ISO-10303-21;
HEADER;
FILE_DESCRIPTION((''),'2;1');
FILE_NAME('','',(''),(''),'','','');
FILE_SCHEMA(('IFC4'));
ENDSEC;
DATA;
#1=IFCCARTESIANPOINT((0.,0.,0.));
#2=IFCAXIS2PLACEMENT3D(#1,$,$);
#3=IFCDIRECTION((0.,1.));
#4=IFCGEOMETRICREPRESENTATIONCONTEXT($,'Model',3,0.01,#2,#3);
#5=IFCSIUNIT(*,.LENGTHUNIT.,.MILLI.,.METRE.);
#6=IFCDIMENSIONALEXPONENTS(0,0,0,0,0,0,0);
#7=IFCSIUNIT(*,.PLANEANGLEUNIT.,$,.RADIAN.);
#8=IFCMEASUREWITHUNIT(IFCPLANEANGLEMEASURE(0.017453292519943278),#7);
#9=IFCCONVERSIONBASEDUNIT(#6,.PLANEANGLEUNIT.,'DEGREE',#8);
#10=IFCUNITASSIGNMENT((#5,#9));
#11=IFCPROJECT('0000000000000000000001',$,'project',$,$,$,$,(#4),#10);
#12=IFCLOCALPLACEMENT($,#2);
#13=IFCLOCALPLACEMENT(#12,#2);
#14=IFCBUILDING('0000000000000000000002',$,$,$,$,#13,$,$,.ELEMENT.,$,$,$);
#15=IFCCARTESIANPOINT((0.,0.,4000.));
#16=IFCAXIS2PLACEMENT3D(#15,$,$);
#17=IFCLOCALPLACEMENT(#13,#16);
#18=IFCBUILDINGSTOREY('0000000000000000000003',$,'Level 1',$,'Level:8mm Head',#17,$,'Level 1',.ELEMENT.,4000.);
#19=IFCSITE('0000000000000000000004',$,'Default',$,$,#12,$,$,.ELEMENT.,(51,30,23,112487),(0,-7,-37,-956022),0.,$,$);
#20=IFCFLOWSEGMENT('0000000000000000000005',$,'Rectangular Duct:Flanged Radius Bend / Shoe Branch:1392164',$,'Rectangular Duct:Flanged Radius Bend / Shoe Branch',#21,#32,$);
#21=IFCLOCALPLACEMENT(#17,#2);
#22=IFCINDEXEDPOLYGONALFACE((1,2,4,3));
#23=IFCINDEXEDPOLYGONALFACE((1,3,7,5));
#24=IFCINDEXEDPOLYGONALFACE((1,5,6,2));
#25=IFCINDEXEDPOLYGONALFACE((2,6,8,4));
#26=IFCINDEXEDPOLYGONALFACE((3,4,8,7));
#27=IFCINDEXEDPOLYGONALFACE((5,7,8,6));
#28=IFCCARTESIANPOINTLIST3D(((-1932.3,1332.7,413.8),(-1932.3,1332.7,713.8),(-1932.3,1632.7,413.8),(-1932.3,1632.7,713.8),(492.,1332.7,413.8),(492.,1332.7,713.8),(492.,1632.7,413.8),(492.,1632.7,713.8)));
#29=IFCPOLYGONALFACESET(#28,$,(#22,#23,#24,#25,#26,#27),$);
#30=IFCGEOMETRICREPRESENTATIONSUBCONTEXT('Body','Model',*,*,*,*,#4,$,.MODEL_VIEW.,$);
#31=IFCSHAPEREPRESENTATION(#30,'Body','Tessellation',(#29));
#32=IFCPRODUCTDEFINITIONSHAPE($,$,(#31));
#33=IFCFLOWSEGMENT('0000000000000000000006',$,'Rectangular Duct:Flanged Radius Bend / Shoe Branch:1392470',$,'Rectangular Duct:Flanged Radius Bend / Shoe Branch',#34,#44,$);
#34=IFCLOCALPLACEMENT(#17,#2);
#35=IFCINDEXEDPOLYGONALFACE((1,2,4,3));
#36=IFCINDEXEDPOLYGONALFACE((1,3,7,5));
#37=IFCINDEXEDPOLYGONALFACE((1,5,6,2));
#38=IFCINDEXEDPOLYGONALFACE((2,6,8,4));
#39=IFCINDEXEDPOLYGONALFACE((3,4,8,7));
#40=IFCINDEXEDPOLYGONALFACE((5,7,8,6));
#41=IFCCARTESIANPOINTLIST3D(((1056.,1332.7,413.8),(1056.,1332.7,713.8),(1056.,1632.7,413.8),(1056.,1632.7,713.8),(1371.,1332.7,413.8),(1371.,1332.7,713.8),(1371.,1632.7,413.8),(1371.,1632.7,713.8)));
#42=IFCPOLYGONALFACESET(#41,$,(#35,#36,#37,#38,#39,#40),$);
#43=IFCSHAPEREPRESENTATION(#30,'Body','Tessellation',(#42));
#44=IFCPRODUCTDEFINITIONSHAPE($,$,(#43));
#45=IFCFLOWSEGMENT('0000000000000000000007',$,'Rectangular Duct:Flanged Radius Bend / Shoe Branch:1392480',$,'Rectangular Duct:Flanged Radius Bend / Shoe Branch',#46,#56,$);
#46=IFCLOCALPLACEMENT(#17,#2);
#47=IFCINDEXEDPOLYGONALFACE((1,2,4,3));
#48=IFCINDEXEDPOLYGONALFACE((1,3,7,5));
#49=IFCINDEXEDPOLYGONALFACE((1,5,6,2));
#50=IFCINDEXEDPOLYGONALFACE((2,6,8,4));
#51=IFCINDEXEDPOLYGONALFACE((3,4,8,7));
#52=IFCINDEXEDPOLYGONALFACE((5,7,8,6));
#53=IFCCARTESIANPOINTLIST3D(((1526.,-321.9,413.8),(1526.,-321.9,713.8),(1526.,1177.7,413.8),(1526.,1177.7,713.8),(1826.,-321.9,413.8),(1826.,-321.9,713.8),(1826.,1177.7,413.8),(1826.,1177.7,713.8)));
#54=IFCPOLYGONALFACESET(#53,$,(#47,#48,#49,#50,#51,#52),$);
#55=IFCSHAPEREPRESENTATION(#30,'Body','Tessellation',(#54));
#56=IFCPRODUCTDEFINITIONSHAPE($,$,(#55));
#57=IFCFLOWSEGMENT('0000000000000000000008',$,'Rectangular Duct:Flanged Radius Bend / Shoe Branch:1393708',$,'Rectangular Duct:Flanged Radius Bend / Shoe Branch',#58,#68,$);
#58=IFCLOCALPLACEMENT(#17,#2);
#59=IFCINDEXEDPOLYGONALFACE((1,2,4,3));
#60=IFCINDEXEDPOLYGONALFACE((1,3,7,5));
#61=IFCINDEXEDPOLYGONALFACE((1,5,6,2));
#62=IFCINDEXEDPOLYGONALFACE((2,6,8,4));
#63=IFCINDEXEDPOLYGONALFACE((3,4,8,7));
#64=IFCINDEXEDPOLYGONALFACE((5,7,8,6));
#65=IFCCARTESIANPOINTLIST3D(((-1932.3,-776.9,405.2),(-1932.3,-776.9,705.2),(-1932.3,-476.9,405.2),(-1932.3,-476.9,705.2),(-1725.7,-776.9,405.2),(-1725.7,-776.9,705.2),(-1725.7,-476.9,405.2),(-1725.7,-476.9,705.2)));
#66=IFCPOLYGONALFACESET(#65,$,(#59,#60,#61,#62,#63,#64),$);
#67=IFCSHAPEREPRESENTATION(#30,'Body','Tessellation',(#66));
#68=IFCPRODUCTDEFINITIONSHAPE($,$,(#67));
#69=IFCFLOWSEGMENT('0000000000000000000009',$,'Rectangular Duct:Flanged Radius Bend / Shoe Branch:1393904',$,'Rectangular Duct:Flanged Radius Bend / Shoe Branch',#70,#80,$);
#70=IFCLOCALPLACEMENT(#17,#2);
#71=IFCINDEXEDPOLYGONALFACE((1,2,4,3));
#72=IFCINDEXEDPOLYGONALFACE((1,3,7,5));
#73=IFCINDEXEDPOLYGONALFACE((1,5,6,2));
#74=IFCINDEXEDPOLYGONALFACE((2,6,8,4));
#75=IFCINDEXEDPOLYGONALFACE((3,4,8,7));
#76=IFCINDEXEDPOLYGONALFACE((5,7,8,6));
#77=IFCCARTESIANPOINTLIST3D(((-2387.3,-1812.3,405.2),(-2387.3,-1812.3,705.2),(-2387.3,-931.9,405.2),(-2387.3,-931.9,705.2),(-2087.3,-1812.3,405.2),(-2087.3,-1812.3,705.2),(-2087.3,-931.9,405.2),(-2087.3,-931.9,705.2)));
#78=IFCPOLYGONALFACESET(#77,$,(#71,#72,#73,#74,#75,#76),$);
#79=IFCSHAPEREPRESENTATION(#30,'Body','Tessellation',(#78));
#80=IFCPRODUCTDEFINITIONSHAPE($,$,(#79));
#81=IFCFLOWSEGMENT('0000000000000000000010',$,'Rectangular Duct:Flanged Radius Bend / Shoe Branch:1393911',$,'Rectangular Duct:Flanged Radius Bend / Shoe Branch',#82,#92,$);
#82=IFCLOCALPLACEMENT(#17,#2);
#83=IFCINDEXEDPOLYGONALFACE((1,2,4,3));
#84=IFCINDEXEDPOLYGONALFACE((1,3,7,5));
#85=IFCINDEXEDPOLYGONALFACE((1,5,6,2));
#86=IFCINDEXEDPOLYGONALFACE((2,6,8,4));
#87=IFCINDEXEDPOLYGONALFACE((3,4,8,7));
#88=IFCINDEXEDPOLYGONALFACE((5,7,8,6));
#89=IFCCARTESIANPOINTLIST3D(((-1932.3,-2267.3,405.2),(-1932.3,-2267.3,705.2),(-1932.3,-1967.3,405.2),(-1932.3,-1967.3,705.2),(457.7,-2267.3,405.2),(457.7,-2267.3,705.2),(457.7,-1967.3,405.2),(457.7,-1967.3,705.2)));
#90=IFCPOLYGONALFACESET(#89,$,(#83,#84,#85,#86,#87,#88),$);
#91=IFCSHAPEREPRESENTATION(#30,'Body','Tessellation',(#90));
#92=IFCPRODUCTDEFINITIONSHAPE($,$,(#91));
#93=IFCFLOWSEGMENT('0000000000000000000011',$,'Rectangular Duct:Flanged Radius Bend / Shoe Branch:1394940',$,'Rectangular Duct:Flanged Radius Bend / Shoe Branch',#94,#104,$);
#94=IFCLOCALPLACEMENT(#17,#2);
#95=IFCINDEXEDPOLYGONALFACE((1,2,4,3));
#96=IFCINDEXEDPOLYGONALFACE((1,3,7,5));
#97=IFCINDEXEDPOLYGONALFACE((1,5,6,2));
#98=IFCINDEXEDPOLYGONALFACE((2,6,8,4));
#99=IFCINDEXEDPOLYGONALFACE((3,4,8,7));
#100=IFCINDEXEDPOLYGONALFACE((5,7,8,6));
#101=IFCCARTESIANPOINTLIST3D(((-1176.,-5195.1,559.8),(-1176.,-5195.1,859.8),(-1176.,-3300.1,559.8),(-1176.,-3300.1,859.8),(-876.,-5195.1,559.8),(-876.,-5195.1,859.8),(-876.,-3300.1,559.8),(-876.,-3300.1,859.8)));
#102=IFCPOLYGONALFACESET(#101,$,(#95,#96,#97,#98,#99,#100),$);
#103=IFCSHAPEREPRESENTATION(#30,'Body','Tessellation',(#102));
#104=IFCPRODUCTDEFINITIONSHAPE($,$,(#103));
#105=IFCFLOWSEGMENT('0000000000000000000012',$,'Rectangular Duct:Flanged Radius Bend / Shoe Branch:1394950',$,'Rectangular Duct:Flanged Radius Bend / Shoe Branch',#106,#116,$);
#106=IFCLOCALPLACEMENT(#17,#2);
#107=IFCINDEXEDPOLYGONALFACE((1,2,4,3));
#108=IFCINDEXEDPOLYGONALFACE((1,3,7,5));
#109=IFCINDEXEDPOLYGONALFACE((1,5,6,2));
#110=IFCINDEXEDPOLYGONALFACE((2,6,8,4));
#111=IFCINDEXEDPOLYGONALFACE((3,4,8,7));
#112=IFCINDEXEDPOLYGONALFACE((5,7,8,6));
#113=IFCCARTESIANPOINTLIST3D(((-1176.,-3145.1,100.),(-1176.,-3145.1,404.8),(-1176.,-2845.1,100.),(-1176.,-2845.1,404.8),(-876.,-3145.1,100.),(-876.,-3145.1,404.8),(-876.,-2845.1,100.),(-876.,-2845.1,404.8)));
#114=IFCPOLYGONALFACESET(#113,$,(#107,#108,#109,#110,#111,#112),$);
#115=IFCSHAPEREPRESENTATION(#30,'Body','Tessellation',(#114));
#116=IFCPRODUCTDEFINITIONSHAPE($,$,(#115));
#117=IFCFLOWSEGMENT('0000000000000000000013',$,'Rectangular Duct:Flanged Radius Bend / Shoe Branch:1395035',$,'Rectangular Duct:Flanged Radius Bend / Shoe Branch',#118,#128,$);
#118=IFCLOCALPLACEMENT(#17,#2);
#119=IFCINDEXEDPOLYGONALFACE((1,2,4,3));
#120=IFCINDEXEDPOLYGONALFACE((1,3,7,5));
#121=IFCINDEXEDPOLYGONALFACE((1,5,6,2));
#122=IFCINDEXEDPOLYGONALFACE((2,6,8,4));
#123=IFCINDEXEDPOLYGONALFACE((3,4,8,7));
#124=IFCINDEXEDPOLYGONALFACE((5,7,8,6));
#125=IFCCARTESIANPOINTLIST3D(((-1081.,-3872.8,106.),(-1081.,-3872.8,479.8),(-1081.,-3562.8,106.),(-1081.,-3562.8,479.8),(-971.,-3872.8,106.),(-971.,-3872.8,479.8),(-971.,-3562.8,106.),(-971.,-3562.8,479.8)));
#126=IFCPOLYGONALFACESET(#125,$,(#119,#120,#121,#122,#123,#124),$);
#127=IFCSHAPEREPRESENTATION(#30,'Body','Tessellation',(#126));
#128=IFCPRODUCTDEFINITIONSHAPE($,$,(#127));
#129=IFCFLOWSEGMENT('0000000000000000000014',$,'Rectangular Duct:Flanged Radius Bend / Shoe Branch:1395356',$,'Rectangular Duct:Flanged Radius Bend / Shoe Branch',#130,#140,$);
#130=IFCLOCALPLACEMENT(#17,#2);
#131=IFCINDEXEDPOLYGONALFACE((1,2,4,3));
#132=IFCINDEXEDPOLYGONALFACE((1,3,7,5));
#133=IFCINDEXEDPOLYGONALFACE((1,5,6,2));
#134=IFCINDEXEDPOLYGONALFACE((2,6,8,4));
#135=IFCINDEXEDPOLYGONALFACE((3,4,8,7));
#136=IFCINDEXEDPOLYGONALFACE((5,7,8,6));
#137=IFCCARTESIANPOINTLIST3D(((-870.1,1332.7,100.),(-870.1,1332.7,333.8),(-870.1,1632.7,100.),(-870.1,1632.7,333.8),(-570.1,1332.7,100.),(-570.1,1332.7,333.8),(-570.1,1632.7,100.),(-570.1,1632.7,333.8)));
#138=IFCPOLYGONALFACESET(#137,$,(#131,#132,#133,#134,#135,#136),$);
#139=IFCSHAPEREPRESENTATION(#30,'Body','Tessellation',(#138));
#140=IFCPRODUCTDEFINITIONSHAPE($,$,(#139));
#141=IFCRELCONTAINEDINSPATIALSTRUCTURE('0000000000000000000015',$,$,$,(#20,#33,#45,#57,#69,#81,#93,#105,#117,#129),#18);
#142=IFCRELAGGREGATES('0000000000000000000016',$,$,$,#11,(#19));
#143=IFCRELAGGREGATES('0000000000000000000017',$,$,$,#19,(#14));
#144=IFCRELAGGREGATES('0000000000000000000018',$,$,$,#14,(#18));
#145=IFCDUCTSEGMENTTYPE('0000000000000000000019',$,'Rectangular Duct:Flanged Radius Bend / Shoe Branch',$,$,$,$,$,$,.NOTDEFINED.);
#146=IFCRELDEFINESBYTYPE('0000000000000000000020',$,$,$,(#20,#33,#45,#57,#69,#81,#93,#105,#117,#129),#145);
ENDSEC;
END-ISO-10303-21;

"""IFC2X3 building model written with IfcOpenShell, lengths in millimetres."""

from ifc_helpers import new_model, entity, si_unit, converted_unit, direction, frame, frame_2d, origin, origin_2d_with_axis, place, context, subcontext, project, spatial, rectangle, extrude, type_object, element, save


model = new_model("IFC2X3")

# Units and contexts
model_context = context("Model", 3, precision=0.01, world=origin(), true_north=direction((0.0, 1.0)))
body_context = subcontext(model_context, "Body", "Model", "MODEL_VIEW")
ifc_project = project(units=[si_unit("LENGTHUNIT", "METRE", prefix="MILLI"), converted_unit("PLANEANGLEUNIT", "DEGREE", entity("IfcPlaneAngleMeasure", 0.017453292519943278), si_unit("PLANEANGLEUNIT", "RADIAN"), dimensions=[0, 0, 0, 0, 0, 0, 0])], contexts=[model_context])

# Site, building, storey
site_placement = place(None, origin())
site = spatial("IfcSite", under=ifc_project, at=site_placement, Name="Default", CompositionType="ELEMENT", RefLatitude=(51, 30, 23, 112487), RefLongitude=(0, -7, -37, -956022), RefElevation=0.0)
building_placement = place(site_placement, origin())
building = spatial("IfcBuilding", under=site, at=building_placement, CompositionType="ELEMENT")
storey_placement = place(building_placement, frame((0.0, 0.0, 4000.0)))
storey = spatial("IfcBuildingStorey", under=building, at=storey_placement, Name="Level 1", ObjectType="Level:8mm Head", LongName="Level 1", CompositionType="ELEMENT", Elevation=4000.0)

# Flow segments
duct_segment_type = type_object("IfcDuctSegmentType", Name="Rectangular Duct:Flanged Radius Bend / Shoe Branch", PredefinedType="NOTDEFINED")
flow_segment_1_placement = place(storey_placement, origin())
element("IfcFlowSegment", 1, at=flow_segment_1_placement, inside=storey, type_object=duct_segment_type, Name="Rectangular Duct:Flanged Radius Bend / Shoe Branch:1392164", ObjectType="Rectangular Duct:Flanged Radius Bend / Shoe Branch", context=body_context, shape_type="SweptSolid", body=[
    extrude(rectangle(XDim=2424.3, YDim=300.0, at=frame_2d((0.0, 0.0), x_axis=(1.0, 0.0))), frame((-720.1, 1482.7, 413.8)), (0.0, 0.0, 1.0), 300.0),
])
flow_segment_2_placement = place(storey_placement, origin())
element("IfcFlowSegment", 2, at=flow_segment_2_placement, inside=storey, type_object=duct_segment_type, Name="Rectangular Duct:Flanged Radius Bend / Shoe Branch:1392470", ObjectType="Rectangular Duct:Flanged Radius Bend / Shoe Branch", context=body_context, shape_type="SweptSolid", body=[
    extrude(rectangle(XDim=315.0, YDim=300.0, at=frame_2d((0.0, 0.0), x_axis=(1.0, 0.0))), frame((1213.5, 1482.7, 413.8)), (0.0, 0.0, 1.0), 300.0),
])
flow_segment_3_placement = place(storey_placement, origin())
element("IfcFlowSegment", 3, at=flow_segment_3_placement, inside=storey, type_object=duct_segment_type, Name="Rectangular Duct:Flanged Radius Bend / Shoe Branch:1392480", ObjectType="Rectangular Duct:Flanged Radius Bend / Shoe Branch", context=body_context, shape_type="SweptSolid", body=[
    extrude(rectangle(XDim=1499.6, YDim=300.0, at=origin_2d_with_axis()), frame((1676.0, 427.9, 413.8), z_axis=(0.0, 0.0, 1.0), x_axis=(0.0, -1.0, 0.0)), (0.0, 0.0, 1.0), 300.0),
])
flow_segment_4_placement = place(storey_placement, origin())
element("IfcFlowSegment", 4, at=flow_segment_4_placement, inside=storey, type_object=duct_segment_type, Name="Rectangular Duct:Flanged Radius Bend / Shoe Branch:1393708", ObjectType="Rectangular Duct:Flanged Radius Bend / Shoe Branch", context=body_context, shape_type="SweptSolid", body=[
    extrude(rectangle(XDim=206.6, YDim=300.0, at=frame_2d((0.0, 0.0), x_axis=(1.0, 0.0))), frame((-1829.0, -626.9, 405.2), z_axis=(0.0, 0.0, 1.0), x_axis=(-1.0, 0.0, 0.0)), (0.0, 0.0, 1.0), 300.0),
])
flow_segment_5_placement = place(storey_placement, origin())
element("IfcFlowSegment", 5, at=flow_segment_5_placement, inside=storey, type_object=duct_segment_type, Name="Rectangular Duct:Flanged Radius Bend / Shoe Branch:1393904", ObjectType="Rectangular Duct:Flanged Radius Bend / Shoe Branch", context=body_context, shape_type="SweptSolid", body=[
    extrude(rectangle(XDim=880.4, YDim=300.0, at=frame_2d((0.0, 0.0), x_axis=(1.0, 0.0))), frame((-2237.3, -1372.1, 405.2), z_axis=(0.0, 0.0, 1.0), x_axis=(0.0, -1.0, 0.0)), (0.0, 0.0, 1.0), 300.0),
])
flow_segment_6_placement = place(storey_placement, origin())
element("IfcFlowSegment", 6, at=flow_segment_6_placement, inside=storey, type_object=duct_segment_type, Name="Rectangular Duct:Flanged Radius Bend / Shoe Branch:1393911", ObjectType="Rectangular Duct:Flanged Radius Bend / Shoe Branch", context=body_context, shape_type="SweptSolid", body=[
    extrude(rectangle(XDim=2390.0, YDim=300.0, at=origin_2d_with_axis()), frame((-737.3, -2117.3, 405.2)), (0.0, 0.0, 1.0), 300.0),
])
flow_segment_7_placement = place(storey_placement, origin())
element("IfcFlowSegment", 7, at=flow_segment_7_placement, inside=storey, type_object=duct_segment_type, Name="Rectangular Duct:Flanged Radius Bend / Shoe Branch:1394940", ObjectType="Rectangular Duct:Flanged Radius Bend / Shoe Branch", context=body_context, shape_type="SweptSolid", body=[
    extrude(rectangle(XDim=1895.0, YDim=300.0, at=origin_2d_with_axis()), frame((-1026.0, -4247.6, 559.8), z_axis=(0.0, 0.0, 1.0), x_axis=(0.0, -1.0, 0.0)), (0.0, 0.0, 1.0), 300.0),
])
flow_segment_8_placement = place(storey_placement, origin())
element("IfcFlowSegment", 8, at=flow_segment_8_placement, inside=storey, type_object=duct_segment_type, Name="Rectangular Duct:Flanged Radius Bend / Shoe Branch:1394950", ObjectType="Rectangular Duct:Flanged Radius Bend / Shoe Branch", context=body_context, shape_type="SweptSolid", body=[
    extrude(rectangle(XDim=300.0, YDim=300.0, at=origin_2d_with_axis()), frame((-1026.0, -2995.1, 100.0), z_axis=(0.0, 0.0, 1.0), x_axis=(0.0, 1.0, 0.0)), (0.0, 0.0, 1.0), 304.8),
])
flow_segment_9_placement = place(storey_placement, origin())
element("IfcFlowSegment", 9, at=flow_segment_9_placement, inside=storey, type_object=duct_segment_type, Name="Rectangular Duct:Flanged Radius Bend / Shoe Branch:1395035", ObjectType="Rectangular Duct:Flanged Radius Bend / Shoe Branch", context=body_context, shape_type="SweptSolid", body=[
    extrude(rectangle(XDim=110.0, YDim=310.0, at=origin_2d_with_axis()), frame((-1026.0, -3717.8, 106.0)), (0.0, 0.0, 1.0), 373.8),
])
flow_segment_10_placement = place(storey_placement, origin())
element("IfcFlowSegment", 10, at=flow_segment_10_placement, inside=storey, type_object=duct_segment_type, Name="Rectangular Duct:Flanged Radius Bend / Shoe Branch:1395356", ObjectType="Rectangular Duct:Flanged Radius Bend / Shoe Branch", context=body_context, shape_type="SweptSolid", body=[
    extrude(rectangle(XDim=300.0, YDim=300.0, at=origin_2d_with_axis()), frame((-720.1, 1482.7, 100.0), z_axis=(0.0, 0.0, 1.0), x_axis=(0.0, 1.0, 0.0)), (0.0, 0.0, 1.0), 233.8),
])

save(model, "model.ifc")
